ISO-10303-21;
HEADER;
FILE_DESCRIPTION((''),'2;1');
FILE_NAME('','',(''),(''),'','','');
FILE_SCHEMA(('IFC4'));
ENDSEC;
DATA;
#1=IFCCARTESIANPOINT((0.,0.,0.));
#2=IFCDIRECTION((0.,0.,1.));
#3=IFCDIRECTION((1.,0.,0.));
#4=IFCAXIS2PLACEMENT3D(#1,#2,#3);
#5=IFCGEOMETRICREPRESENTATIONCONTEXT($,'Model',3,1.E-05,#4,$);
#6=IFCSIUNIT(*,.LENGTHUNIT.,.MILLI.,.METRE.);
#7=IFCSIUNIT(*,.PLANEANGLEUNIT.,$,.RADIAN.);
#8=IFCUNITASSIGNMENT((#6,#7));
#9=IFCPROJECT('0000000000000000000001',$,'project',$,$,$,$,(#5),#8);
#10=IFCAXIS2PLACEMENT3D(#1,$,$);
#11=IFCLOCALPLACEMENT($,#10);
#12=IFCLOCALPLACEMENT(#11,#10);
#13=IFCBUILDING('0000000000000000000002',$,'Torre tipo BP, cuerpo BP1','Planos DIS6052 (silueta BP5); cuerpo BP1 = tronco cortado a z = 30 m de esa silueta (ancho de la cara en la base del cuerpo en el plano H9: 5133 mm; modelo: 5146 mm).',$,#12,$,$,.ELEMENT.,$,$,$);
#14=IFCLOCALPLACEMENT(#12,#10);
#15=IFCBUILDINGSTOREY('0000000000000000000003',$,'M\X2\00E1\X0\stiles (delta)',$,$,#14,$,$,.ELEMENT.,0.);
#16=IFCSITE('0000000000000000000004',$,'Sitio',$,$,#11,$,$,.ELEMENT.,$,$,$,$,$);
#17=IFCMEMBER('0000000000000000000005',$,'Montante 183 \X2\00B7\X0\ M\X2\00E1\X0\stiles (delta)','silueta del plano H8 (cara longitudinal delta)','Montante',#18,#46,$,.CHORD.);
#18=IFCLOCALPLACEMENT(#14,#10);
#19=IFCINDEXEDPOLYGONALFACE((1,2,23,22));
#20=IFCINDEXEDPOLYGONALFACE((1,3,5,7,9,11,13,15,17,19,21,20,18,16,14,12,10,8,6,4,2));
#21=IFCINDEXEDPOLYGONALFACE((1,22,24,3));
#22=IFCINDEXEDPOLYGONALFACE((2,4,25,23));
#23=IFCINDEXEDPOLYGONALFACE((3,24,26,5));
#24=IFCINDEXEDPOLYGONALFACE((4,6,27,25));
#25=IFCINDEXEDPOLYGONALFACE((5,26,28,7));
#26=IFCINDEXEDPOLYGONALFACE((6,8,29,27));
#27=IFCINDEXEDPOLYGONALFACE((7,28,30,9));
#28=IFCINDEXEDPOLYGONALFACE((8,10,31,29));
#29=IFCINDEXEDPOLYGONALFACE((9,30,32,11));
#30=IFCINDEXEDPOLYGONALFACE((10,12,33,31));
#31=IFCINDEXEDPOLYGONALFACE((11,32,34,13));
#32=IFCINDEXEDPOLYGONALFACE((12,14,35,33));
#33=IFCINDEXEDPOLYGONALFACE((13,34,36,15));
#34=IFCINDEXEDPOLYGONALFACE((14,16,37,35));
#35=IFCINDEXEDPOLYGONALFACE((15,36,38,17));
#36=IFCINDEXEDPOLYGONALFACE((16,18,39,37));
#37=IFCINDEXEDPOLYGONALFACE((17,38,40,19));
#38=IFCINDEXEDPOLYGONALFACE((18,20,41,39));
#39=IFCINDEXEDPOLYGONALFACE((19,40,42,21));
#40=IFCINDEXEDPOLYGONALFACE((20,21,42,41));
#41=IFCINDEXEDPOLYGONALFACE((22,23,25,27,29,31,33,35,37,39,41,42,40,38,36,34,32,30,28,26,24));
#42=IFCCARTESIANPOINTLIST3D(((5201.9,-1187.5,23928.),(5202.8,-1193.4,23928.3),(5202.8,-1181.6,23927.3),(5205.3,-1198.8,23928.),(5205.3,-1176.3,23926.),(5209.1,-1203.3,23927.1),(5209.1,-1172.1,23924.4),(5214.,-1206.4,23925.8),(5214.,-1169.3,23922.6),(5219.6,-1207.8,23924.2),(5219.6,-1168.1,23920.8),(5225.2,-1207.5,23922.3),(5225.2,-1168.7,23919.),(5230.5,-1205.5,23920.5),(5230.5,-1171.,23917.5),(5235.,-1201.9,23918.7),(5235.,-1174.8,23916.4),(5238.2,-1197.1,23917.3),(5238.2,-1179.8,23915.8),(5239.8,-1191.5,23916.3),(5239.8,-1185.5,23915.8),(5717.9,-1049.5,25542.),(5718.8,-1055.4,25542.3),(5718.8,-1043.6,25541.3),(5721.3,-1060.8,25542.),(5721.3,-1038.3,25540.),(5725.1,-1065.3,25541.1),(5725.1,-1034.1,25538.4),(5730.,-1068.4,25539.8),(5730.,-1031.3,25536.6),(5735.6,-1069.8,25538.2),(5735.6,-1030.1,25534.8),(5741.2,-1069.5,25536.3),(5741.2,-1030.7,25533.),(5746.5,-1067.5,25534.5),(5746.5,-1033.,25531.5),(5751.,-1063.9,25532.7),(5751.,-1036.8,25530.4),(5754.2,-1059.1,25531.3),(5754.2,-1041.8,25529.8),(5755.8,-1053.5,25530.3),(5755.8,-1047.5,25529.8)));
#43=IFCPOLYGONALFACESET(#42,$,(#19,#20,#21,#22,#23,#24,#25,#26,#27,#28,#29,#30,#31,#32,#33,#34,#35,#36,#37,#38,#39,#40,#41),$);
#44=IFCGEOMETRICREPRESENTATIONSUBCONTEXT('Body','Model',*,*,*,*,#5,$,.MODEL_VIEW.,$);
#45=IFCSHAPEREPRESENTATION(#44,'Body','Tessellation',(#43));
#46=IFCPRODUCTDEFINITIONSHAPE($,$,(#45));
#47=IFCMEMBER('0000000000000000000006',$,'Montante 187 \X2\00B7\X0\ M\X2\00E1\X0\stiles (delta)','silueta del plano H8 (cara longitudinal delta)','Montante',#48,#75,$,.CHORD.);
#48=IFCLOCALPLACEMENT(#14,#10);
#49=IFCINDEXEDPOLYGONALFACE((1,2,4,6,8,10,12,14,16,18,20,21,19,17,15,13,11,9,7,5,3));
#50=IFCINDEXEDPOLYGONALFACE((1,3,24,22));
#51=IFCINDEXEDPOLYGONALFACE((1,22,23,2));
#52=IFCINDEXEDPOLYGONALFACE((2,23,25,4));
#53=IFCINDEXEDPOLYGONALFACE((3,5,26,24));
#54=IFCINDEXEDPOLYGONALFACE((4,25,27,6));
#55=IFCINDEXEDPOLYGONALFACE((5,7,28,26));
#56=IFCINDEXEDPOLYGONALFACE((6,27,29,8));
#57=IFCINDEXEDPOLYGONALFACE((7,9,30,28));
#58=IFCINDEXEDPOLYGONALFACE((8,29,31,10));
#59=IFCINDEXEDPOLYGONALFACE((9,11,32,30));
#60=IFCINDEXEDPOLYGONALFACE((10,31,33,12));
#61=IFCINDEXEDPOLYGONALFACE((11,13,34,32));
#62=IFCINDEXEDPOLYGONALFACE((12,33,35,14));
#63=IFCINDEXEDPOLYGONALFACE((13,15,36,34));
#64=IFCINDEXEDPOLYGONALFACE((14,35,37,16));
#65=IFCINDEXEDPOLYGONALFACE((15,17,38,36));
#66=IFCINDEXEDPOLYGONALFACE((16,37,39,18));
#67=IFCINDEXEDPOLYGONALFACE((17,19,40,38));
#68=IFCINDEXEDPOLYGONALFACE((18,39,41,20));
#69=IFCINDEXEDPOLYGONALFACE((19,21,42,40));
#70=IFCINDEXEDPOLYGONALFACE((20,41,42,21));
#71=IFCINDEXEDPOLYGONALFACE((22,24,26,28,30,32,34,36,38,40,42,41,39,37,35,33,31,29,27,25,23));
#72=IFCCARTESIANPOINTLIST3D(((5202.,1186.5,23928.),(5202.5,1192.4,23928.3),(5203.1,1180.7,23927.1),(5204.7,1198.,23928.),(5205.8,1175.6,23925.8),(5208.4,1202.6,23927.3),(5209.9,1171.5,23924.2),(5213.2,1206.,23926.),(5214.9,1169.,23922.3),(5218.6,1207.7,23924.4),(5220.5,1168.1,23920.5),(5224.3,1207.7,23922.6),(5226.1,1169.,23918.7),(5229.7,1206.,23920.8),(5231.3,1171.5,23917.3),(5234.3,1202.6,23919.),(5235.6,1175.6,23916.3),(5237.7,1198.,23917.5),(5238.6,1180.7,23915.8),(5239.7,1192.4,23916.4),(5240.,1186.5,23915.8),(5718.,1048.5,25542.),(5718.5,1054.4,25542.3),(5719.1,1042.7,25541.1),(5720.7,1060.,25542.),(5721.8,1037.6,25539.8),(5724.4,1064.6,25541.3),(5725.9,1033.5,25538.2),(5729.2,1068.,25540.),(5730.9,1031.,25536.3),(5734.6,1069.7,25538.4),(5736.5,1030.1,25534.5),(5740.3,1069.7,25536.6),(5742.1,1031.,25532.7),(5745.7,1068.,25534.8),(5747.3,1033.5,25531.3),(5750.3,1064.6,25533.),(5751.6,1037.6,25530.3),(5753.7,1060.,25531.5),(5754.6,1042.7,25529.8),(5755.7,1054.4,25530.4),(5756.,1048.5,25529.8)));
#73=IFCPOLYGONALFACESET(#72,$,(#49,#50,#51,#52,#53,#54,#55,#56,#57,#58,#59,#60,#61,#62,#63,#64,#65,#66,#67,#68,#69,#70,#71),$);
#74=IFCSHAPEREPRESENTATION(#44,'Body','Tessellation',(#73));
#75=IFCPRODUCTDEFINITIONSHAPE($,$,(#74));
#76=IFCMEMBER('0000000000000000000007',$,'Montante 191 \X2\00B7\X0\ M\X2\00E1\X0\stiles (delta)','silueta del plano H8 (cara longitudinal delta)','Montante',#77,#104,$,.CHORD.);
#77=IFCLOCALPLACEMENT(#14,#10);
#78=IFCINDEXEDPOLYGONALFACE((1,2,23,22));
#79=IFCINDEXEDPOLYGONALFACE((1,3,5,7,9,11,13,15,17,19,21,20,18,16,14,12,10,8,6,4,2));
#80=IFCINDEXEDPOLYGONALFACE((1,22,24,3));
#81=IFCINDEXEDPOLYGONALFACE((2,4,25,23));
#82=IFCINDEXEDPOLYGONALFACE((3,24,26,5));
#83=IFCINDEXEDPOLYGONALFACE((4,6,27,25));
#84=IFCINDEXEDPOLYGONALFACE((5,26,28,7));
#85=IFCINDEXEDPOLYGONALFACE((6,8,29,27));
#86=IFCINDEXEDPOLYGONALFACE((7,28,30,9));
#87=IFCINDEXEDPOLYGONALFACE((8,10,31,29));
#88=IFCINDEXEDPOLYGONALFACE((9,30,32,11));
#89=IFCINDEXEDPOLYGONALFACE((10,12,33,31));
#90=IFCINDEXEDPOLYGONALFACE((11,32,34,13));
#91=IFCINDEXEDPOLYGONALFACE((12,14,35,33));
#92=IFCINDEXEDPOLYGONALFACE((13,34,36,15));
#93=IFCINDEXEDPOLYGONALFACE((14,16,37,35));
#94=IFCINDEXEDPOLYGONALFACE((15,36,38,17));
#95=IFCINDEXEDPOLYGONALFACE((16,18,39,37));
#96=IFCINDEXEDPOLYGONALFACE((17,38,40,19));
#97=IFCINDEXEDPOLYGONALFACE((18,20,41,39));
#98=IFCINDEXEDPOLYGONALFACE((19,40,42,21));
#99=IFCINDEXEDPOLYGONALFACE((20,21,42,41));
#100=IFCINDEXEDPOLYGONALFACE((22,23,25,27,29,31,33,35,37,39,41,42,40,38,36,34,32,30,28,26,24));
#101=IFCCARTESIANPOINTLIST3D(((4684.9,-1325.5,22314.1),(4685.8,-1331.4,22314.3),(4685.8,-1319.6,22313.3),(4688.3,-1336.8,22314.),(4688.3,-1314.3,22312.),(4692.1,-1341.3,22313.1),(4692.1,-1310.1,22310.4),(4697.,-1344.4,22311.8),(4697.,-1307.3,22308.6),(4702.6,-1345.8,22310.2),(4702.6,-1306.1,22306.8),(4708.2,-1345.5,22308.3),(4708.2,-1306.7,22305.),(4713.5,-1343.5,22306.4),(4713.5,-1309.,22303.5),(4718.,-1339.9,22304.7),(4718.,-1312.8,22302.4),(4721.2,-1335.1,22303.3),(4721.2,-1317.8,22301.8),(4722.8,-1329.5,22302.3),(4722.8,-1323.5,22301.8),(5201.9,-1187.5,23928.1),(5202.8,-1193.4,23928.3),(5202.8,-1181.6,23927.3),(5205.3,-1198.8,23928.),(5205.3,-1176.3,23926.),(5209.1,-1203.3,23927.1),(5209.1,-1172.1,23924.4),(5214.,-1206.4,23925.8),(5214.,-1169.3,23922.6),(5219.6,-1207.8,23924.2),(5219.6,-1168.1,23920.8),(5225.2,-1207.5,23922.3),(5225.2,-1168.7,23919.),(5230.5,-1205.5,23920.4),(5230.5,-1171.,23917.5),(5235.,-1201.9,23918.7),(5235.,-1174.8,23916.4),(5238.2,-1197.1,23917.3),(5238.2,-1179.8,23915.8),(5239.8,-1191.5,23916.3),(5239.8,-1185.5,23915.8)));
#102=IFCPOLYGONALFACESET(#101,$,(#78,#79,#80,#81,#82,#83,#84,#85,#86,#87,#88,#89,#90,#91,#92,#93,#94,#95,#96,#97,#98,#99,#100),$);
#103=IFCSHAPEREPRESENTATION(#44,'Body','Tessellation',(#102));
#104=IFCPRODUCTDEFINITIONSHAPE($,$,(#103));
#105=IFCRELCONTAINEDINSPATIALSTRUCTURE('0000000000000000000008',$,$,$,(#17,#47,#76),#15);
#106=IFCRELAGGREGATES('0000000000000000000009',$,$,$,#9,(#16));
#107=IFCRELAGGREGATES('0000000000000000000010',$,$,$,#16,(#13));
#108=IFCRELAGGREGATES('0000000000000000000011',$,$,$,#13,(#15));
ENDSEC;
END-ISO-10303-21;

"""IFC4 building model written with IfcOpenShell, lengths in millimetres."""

from ifc_helpers import new_model, si_unit, frame, origin, origin_with_axes, place, context, subcontext, project, spatial, circle, extrude, element, save


model = new_model("IFC4")

# Units and contexts
model_context = context("Model", 3, precision=1e-05, world=origin_with_axes())
body_context = subcontext(model_context, "Body", "Model", "MODEL_VIEW")
ifc_project = project(units=[si_unit("LENGTHUNIT", "METRE", prefix="MILLI"), si_unit("PLANEANGLEUNIT", "RADIAN")], contexts=[model_context])

# Site, building, storey
site_placement = place(None, origin())
site = spatial("IfcSite", under=ifc_project, at=site_placement, Name="Sitio", CompositionType="ELEMENT")
building_placement = place(site_placement, origin())
building = spatial("IfcBuilding", under=site, at=building_placement, Name="Torre tipo BP, cuerpo BP1", Description="Planos DIS6052 (silueta BP5); cuerpo BP1 = tronco cortado a z = 30 m de esa silueta (ancho de la cara en la base del cuerpo en el plano H9: 5133 mm; modelo: 5146 mm).", CompositionType="ELEMENT")
storey_placement = place(building_placement, origin())
storey = spatial("IfcBuildingStorey", under=building, at=storey_placement, Name="Mástiles (delta)", CompositionType="ELEMENT", Elevation=0.0)

# Members
for number, where, z_axis, x_axis, name in (
    (1, (5737.0, -1050.0, 25536.0), (-0.303514, -0.081172, -0.949363), (-0.952827, 0.025857, 0.30241), "Montante 183 · Mástiles (delta)"),
    (2, (5737.0, 1050.0, 25536.0), (-0.303514, 0.081172, -0.949363), (-0.024718, -0.9967, -0.077317), "Montante 187 · Mástiles (delta)"),
):
    element("IfcMember", number, at=place(storey_placement, frame(where, z_axis=z_axis, x_axis=x_axis)), inside=storey, Name=name, Description="silueta del plano H8 (cara longitudinal delta)", ObjectType="Montante", PredefinedType="CHORD", context=body_context, shape_type="SweptSolid", body=[
        extrude(circle(Radius=20.0), None, (0.0, 0.0, 1.0), 1700.1),
    ])
for number, where, z_axis, x_axis, name in (
    (3, (5221.0, -1188.0, 23922.0), (-0.304048, -0.081158, -0.949194), (-0.952657, 0.025902, 0.302942), "Montante 191 · Mástiles (delta)"),
):
    element("IfcMember", number, at=place(storey_placement, frame(where, z_axis=z_axis, x_axis=x_axis)), inside=storey, Name=name, Description="silueta del plano H8 (cara longitudinal delta)", ObjectType="Montante", PredefinedType="CHORD", context=body_context, shape_type="SweptSolid", body=[
        extrude(circle(Radius=20.0), None, (0.0, 0.0, 1.0), 1700.4),
    ])

save(model, "model.ifc")
